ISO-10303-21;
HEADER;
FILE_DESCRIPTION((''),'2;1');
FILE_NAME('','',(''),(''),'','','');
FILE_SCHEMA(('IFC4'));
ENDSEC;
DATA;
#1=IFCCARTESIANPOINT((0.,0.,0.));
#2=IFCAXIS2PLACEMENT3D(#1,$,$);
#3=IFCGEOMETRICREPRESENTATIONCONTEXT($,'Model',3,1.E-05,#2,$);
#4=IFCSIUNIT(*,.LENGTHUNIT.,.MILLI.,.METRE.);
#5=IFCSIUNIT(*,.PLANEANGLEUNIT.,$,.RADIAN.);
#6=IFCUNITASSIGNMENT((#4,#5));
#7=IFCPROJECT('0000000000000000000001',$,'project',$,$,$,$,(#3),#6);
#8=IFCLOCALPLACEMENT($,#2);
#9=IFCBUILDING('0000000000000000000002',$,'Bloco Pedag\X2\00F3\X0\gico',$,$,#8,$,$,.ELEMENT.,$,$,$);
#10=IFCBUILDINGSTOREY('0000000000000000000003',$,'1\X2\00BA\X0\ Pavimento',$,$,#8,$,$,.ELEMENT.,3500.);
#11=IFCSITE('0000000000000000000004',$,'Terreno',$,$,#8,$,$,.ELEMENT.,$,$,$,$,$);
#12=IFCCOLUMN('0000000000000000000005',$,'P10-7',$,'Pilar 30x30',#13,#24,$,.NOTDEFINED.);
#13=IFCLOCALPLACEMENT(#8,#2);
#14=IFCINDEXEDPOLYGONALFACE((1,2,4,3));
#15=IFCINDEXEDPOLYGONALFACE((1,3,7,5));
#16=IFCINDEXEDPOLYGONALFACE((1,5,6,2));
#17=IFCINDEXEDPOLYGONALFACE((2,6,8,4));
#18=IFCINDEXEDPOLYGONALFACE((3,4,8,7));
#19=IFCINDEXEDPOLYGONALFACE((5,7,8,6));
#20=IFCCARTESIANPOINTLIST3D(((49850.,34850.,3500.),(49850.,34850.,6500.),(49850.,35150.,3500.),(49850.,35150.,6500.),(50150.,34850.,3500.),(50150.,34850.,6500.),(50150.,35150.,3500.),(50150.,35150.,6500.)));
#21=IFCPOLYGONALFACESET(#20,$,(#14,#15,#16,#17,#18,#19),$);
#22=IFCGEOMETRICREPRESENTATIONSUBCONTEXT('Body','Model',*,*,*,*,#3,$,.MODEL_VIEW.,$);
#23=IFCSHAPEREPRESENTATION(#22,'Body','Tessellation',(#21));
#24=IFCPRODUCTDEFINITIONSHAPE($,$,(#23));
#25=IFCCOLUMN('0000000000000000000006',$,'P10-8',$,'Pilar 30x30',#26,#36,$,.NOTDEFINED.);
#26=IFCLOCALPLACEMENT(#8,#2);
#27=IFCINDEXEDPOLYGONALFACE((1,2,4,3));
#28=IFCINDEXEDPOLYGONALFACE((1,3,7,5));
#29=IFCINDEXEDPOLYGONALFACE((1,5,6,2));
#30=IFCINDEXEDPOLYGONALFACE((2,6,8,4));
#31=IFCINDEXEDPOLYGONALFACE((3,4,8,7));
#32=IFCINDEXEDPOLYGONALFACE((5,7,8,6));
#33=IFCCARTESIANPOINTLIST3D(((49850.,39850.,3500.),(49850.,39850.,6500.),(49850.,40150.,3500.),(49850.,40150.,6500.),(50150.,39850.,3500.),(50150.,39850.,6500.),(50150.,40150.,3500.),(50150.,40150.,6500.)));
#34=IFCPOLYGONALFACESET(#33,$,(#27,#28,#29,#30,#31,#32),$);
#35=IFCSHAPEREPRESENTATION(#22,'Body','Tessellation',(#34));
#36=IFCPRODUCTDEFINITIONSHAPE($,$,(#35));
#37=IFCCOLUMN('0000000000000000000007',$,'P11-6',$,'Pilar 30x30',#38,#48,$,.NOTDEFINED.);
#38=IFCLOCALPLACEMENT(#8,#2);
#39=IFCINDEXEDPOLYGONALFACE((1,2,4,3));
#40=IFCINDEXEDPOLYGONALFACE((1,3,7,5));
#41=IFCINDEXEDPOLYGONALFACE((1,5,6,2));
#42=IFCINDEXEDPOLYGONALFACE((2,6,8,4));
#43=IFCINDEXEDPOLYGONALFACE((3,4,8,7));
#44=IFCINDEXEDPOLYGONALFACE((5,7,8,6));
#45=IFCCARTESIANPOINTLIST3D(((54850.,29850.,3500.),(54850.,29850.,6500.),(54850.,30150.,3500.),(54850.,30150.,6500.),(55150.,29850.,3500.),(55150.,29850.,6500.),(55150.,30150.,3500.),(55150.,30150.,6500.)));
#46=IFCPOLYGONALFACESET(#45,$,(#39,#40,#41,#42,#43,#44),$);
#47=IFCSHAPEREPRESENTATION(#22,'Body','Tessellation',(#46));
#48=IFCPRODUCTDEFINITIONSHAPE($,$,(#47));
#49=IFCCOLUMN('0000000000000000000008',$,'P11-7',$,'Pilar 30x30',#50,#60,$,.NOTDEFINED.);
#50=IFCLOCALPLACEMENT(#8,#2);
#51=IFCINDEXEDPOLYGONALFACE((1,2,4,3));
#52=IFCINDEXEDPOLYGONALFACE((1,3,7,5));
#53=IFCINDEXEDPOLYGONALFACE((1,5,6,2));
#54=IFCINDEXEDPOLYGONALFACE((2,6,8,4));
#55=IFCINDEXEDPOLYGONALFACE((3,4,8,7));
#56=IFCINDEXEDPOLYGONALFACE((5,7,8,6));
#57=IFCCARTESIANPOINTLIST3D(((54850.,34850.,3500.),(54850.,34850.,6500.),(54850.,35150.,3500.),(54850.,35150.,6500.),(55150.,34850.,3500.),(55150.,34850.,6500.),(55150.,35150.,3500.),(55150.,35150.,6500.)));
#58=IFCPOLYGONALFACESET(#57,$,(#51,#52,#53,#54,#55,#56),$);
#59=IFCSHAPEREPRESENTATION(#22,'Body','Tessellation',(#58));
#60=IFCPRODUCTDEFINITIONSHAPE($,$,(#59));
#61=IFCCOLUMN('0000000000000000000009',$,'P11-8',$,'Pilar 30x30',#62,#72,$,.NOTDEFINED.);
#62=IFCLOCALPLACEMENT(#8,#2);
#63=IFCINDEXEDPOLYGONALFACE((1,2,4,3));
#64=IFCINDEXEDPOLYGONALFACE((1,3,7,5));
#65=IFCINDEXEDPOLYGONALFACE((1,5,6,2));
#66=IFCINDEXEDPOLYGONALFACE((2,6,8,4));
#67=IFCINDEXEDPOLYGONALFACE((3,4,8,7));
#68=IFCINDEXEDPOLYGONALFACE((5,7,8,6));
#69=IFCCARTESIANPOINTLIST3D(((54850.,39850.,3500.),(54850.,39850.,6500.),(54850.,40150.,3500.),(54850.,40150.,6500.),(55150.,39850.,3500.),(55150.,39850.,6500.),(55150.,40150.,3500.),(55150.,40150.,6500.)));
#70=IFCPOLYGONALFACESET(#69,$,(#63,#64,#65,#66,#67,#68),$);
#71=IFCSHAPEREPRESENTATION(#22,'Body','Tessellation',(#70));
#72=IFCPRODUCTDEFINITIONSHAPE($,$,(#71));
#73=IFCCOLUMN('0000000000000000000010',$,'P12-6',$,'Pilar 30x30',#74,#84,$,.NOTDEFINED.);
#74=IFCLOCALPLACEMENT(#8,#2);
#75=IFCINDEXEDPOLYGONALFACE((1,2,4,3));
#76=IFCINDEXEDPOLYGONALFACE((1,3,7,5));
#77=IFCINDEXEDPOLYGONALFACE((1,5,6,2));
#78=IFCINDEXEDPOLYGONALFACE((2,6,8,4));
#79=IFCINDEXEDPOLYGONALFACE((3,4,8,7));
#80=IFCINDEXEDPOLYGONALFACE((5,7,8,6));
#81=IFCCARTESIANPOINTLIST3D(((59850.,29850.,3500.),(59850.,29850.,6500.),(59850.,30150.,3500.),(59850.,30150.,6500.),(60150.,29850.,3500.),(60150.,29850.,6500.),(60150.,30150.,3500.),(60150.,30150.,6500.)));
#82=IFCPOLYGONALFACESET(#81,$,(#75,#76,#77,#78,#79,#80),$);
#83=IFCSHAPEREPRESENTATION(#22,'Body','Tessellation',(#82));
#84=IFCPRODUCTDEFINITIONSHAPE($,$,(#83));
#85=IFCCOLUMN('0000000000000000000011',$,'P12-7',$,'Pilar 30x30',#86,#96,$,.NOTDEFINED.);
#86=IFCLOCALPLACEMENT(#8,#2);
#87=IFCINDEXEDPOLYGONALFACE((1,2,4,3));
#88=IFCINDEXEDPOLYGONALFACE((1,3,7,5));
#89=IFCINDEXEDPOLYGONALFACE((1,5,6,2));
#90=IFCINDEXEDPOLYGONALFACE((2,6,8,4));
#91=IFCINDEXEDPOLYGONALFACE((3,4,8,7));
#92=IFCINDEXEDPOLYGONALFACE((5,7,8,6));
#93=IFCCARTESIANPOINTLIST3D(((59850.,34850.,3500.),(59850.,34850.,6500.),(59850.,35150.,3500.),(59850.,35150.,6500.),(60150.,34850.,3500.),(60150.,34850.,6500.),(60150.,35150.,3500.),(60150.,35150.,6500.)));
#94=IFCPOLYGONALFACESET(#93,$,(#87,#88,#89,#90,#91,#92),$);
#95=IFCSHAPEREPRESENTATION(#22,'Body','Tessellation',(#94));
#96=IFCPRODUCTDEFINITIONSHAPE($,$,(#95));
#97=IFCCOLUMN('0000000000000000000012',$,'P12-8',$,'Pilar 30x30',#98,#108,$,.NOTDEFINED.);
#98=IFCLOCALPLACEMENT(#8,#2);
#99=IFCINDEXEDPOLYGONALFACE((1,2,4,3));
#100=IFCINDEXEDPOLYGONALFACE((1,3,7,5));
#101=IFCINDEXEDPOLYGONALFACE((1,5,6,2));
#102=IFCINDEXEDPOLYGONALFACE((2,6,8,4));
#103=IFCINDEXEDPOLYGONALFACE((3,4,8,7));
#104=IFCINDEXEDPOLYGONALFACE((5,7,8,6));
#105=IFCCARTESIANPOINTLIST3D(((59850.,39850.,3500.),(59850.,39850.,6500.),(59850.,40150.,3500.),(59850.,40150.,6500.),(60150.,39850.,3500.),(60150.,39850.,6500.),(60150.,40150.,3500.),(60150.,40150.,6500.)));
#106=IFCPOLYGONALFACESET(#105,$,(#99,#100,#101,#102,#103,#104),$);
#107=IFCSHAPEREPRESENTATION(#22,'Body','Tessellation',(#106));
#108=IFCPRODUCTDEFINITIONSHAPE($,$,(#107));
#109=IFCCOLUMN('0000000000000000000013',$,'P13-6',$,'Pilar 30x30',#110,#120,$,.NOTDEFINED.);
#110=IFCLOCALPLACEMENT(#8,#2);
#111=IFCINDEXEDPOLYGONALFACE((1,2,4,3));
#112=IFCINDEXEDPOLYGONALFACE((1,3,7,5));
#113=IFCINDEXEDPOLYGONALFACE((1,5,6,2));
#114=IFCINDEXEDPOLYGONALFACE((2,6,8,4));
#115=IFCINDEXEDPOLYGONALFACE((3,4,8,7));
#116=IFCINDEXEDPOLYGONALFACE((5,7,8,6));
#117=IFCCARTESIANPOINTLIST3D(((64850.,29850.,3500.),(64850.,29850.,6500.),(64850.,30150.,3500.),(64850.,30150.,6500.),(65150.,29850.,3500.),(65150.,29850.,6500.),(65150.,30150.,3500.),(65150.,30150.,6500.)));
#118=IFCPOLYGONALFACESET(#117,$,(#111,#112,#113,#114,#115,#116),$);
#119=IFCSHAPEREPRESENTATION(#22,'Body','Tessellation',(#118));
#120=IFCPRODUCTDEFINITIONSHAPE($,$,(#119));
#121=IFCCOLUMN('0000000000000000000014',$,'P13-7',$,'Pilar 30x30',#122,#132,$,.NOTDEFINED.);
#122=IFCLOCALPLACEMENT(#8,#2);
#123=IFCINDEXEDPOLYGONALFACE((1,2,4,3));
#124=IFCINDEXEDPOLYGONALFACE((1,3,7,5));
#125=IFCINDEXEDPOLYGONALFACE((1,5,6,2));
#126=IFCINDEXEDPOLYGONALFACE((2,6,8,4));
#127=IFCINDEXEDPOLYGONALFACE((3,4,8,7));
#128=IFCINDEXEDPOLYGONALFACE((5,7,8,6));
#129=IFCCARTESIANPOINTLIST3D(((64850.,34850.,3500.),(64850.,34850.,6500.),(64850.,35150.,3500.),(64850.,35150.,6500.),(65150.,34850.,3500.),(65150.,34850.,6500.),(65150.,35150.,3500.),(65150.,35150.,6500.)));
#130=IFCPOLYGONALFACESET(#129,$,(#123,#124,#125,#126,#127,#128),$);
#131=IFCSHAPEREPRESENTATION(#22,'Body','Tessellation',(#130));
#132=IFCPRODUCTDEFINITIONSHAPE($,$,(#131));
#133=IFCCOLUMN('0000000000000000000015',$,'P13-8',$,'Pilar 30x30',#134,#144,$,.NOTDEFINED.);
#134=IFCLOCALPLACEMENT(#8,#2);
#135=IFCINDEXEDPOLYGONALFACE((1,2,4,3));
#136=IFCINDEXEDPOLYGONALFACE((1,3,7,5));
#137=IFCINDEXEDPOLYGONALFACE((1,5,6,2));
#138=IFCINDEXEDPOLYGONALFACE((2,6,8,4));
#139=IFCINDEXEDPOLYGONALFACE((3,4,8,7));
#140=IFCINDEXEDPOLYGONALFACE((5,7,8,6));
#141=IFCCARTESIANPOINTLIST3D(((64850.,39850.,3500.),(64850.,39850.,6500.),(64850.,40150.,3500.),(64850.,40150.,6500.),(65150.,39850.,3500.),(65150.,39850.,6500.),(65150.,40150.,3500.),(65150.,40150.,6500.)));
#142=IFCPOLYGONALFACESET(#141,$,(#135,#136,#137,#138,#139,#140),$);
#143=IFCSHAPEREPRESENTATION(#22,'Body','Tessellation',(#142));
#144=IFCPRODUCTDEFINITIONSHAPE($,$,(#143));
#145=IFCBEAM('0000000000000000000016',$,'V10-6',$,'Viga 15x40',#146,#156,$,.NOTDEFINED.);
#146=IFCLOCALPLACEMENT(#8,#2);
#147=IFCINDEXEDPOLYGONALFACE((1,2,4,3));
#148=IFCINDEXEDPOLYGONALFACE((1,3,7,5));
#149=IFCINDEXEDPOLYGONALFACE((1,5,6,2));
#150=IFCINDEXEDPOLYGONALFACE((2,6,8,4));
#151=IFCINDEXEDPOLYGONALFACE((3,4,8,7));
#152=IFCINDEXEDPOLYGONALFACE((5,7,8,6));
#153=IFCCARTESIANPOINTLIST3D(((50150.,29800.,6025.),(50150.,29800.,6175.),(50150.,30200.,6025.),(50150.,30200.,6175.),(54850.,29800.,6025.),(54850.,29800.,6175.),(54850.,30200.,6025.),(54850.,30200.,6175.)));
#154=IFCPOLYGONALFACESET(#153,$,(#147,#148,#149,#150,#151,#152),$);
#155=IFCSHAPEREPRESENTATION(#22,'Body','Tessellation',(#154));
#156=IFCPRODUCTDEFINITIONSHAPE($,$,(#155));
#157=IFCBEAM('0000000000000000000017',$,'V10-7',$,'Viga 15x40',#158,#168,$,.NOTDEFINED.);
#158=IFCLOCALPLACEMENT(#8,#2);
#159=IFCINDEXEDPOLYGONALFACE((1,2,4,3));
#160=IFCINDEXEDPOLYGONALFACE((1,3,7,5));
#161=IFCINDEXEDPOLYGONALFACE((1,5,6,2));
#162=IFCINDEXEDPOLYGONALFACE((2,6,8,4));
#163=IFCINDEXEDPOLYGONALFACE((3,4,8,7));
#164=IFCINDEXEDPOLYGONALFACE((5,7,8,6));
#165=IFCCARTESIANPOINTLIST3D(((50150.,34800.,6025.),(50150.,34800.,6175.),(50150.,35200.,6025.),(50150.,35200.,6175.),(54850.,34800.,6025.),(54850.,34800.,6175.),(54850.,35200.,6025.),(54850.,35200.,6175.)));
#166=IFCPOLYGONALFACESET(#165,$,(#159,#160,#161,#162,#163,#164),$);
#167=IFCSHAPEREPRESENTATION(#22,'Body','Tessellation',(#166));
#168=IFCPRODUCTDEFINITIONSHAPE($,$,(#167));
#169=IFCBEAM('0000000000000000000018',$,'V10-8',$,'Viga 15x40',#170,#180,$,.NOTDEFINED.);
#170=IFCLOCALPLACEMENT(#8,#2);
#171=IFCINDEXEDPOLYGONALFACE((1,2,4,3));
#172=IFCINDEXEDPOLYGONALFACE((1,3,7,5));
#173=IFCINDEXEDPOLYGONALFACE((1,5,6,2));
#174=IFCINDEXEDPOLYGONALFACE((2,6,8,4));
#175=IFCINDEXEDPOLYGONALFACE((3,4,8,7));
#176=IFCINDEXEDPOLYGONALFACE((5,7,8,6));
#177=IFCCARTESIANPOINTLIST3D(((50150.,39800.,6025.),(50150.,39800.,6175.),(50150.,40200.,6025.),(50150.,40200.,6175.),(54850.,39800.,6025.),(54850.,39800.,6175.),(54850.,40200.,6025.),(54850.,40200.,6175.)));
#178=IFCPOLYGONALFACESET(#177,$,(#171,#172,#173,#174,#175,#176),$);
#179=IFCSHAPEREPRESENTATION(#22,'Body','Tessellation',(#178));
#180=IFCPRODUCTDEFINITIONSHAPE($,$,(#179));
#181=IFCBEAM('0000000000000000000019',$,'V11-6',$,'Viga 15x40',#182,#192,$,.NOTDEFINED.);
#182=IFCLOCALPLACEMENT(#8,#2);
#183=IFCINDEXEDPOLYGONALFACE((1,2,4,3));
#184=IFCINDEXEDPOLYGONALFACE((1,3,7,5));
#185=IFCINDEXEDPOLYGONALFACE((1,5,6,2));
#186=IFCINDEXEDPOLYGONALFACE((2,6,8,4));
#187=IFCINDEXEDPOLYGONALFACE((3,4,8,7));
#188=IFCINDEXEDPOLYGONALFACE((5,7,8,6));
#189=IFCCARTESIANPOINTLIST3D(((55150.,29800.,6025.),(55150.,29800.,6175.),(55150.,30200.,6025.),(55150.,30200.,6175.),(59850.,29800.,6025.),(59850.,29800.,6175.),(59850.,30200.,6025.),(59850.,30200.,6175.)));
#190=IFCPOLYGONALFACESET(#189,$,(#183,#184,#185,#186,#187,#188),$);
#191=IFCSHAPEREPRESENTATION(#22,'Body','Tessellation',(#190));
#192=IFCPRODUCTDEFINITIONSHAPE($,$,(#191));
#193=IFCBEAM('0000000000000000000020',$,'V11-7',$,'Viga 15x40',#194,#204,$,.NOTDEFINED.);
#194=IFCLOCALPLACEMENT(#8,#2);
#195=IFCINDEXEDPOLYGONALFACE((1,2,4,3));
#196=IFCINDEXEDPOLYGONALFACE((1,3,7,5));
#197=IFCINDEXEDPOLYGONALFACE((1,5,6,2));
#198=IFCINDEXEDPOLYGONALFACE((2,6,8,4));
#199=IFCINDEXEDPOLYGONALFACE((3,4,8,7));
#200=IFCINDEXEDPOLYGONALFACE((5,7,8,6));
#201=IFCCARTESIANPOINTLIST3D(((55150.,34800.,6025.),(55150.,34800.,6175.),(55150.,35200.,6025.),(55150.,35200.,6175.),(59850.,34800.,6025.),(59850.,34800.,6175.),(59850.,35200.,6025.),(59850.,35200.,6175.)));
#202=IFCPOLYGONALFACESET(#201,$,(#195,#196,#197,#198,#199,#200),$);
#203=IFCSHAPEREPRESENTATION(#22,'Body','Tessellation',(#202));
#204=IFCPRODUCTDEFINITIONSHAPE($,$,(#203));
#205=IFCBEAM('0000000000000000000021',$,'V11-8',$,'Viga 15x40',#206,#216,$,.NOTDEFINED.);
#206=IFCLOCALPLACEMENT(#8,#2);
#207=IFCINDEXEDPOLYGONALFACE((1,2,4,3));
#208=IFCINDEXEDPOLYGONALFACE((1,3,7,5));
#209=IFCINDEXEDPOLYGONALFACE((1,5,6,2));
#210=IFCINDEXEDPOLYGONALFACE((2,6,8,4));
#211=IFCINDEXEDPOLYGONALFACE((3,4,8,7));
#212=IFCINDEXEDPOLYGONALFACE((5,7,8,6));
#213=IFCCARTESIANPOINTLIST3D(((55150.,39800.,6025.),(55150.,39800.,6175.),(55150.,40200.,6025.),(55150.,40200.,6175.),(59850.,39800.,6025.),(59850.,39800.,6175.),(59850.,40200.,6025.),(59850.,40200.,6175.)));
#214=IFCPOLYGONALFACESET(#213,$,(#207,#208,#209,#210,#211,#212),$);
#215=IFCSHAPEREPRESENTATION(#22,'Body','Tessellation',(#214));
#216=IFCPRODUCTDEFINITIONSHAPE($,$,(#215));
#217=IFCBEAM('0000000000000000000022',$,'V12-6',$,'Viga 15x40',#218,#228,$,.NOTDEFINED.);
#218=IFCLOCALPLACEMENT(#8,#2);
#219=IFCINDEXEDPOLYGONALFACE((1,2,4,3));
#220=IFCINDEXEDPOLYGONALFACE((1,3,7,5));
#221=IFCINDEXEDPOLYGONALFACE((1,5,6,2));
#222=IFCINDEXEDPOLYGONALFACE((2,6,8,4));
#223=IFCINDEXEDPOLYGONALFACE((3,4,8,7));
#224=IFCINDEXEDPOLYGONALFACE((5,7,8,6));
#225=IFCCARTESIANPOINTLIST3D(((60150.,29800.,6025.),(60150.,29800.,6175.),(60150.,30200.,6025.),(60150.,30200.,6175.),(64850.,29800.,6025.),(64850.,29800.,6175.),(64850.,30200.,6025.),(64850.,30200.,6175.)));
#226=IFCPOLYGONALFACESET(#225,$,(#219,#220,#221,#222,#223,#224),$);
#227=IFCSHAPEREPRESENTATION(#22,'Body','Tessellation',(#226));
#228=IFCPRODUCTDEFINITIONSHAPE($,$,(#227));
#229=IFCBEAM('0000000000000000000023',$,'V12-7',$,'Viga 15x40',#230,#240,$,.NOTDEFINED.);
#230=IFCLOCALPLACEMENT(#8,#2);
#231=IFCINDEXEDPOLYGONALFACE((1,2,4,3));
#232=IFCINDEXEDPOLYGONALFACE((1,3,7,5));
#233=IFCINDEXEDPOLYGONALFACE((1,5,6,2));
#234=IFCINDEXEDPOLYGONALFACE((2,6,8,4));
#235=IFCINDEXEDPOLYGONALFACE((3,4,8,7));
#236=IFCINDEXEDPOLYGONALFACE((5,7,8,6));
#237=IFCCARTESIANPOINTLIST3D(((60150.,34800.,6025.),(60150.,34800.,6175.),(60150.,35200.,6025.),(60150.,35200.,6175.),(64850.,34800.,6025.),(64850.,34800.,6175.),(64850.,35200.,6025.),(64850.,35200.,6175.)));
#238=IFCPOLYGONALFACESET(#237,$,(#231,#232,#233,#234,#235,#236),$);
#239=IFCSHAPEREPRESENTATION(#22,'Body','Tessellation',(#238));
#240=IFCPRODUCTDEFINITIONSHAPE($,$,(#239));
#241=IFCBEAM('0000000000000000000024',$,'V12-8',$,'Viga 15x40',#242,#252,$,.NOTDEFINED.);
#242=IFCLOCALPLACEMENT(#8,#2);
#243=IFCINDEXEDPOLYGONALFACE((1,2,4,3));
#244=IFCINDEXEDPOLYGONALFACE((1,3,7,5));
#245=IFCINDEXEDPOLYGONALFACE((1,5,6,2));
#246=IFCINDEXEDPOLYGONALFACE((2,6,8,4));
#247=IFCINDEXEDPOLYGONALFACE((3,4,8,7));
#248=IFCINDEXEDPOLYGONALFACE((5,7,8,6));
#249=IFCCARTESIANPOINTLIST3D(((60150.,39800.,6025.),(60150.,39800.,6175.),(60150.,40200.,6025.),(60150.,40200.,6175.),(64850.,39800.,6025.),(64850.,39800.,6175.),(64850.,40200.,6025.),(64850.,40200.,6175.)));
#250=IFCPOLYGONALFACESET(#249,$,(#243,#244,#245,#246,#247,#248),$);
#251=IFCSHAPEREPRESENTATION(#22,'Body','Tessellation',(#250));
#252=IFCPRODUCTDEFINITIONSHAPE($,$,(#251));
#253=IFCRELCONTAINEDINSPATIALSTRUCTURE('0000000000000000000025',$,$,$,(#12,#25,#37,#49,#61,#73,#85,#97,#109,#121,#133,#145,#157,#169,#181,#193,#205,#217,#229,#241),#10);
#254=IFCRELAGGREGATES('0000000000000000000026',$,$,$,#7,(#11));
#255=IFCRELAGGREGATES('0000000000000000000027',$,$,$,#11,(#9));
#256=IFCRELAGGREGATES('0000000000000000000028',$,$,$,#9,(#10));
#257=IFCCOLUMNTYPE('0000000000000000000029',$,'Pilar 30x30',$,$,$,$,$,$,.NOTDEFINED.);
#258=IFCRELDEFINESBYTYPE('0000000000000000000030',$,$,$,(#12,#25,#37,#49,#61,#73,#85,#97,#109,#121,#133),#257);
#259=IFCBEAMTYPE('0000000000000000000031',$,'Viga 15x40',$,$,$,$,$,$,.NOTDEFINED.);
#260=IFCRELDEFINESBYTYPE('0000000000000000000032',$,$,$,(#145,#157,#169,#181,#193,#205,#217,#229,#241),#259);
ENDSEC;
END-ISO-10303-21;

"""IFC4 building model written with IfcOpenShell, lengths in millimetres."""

from ifc_helpers import new_model, si_unit, frame, origin, origin_2d, place, context, subcontext, project, spatial, rectangle, extrude, type_object, element, save


model = new_model("IFC4")

# Units and contexts
model_context = context("Model", 3, precision=1e-05, world=origin())
body_context = subcontext(model_context, "Body", "Model", "MODEL_VIEW")
ifc_project = project(units=[si_unit("LENGTHUNIT", "METRE", prefix="MILLI"), si_unit("PLANEANGLEUNIT", "RADIAN")], contexts=[model_context])

# Site, building, storey
placement = place(None, origin())
site = spatial("IfcSite", under=ifc_project, at=placement, Name="Terreno", CompositionType="ELEMENT")
building = spatial("IfcBuilding", under=site, at=placement, Name="Bloco Pedagógico", CompositionType="ELEMENT")
storey = spatial("IfcBuildingStorey", under=building, at=placement, Name="1º Pavimento", CompositionType="ELEMENT", Elevation=3500.0)

# Columns
column_type = type_object("IfcColumnType", Name="Pilar 30x30", PredefinedType="NOTDEFINED")
for number, where, z_axis, x_axis, name in (
    (1, (50000.0, 35000.0, 3500.0), (0.0, 0.0, 1.0), (1.0, 0.0, 0.0), "P10-7"),
    (2, (50000.0, 40000.0, 3500.0), (0.0, 0.0, 1.0), (1.0, 0.0, 0.0), "P10-8"),
    (3, (55000.0, 30000.0, 3500.0), (0.0, 0.0, 1.0), (1.0, 0.0, 0.0), "P11-6"),
    (4, (55000.0, 35000.0, 3500.0), (0.0, 0.0, 1.0), (1.0, 0.0, 0.0), "P11-7"),
    (5, (55000.0, 40000.0, 3500.0), (0.0, 0.0, 1.0), (1.0, 0.0, 0.0), "P11-8"),
    (6, (60000.0, 30000.0, 3500.0), (0.0, 0.0, 1.0), (1.0, 0.0, 0.0), "P12-6"),
    (7, (60000.0, 35000.0, 3500.0), (0.0, 0.0, 1.0), (1.0, 0.0, 0.0), "P12-7"),
    (8, (60000.0, 40000.0, 3500.0), (0.0, 0.0, 1.0), (1.0, 0.0, 0.0), "P12-8"),
    (9, (65000.0, 30000.0, 3500.0), (0.0, 0.0, 1.0), (1.0, 0.0, 0.0), "P13-6"),
    (10, (65000.0, 35000.0, 3500.0), (0.0, 0.0, 1.0), (1.0, 0.0, 0.0), "P13-7"),
    (11, (65000.0, 40000.0, 3500.0), (0.0, 0.0, 1.0), (1.0, 0.0, 0.0), "P13-8"),
):
    element("IfcColumn", number, at=place(None, frame(where, z_axis=z_axis, x_axis=x_axis)), inside=storey, type_object=column_type, Name=name, ObjectType="Pilar 30x30", PredefinedType="NOTDEFINED", context=body_context, shape_type="SweptSolid", body=[
        extrude(rectangle(XDim=300.0, YDim=300.0, at=origin_2d()), None, (0.0, 0.0, 1.0), 3000.0),
    ])

# Beams
beam_type = type_object("IfcBeamType", Name="Viga 15x40", PredefinedType="NOTDEFINED")
for number, where, z_axis, x_axis, name in (
    (12, (50150.0, 30000.0, 6100.0), (1.0, 0.0, 0.0), (0.0, 1.0, 0.0), "V10-6"),
    (13, (50150.0, 35000.0, 6100.0), (1.0, 0.0, 0.0), (0.0, 1.0, 0.0), "V10-7"),
    (14, (50150.0, 40000.0, 6100.0), (1.0, 0.0, 0.0), (0.0, 1.0, 0.0), "V10-8"),
    (15, (55150.0, 30000.0, 6100.0), (1.0, 0.0, 0.0), (0.0, 1.0, 0.0), "V11-6"),
    (16, (55150.0, 35000.0, 6100.0), (1.0, 0.0, 0.0), (0.0, 1.0, 0.0), "V11-7"),
    (17, (55150.0, 40000.0, 6100.0), (1.0, 0.0, 0.0), (0.0, 1.0, 0.0), "V11-8"),
    (18, (60150.0, 30000.0, 6100.0), (1.0, 0.0, 0.0), (0.0, 1.0, 0.0), "V12-6"),
    (19, (60150.0, 35000.0, 6100.0), (1.0, 0.0, 0.0), (0.0, 1.0, 0.0), "V12-7"),
    (20, (60150.0, 40000.0, 6100.0), (1.0, 0.0, 0.0), (0.0, 1.0, 0.0), "V12-8"),
):
    element("IfcBeam", number, at=place(None, frame(where, z_axis=z_axis, x_axis=x_axis)), inside=storey, type_object=beam_type, Name=name, ObjectType="Viga 15x40", PredefinedType="NOTDEFINED", context=body_context, shape_type="SweptSolid", body=[
        extrude(rectangle(XDim=400.0, YDim=150.0, at=origin_2d()), None, (0.0, 0.0, 1.0), 4700.0),
    ])

save(model, "model.ifc")
